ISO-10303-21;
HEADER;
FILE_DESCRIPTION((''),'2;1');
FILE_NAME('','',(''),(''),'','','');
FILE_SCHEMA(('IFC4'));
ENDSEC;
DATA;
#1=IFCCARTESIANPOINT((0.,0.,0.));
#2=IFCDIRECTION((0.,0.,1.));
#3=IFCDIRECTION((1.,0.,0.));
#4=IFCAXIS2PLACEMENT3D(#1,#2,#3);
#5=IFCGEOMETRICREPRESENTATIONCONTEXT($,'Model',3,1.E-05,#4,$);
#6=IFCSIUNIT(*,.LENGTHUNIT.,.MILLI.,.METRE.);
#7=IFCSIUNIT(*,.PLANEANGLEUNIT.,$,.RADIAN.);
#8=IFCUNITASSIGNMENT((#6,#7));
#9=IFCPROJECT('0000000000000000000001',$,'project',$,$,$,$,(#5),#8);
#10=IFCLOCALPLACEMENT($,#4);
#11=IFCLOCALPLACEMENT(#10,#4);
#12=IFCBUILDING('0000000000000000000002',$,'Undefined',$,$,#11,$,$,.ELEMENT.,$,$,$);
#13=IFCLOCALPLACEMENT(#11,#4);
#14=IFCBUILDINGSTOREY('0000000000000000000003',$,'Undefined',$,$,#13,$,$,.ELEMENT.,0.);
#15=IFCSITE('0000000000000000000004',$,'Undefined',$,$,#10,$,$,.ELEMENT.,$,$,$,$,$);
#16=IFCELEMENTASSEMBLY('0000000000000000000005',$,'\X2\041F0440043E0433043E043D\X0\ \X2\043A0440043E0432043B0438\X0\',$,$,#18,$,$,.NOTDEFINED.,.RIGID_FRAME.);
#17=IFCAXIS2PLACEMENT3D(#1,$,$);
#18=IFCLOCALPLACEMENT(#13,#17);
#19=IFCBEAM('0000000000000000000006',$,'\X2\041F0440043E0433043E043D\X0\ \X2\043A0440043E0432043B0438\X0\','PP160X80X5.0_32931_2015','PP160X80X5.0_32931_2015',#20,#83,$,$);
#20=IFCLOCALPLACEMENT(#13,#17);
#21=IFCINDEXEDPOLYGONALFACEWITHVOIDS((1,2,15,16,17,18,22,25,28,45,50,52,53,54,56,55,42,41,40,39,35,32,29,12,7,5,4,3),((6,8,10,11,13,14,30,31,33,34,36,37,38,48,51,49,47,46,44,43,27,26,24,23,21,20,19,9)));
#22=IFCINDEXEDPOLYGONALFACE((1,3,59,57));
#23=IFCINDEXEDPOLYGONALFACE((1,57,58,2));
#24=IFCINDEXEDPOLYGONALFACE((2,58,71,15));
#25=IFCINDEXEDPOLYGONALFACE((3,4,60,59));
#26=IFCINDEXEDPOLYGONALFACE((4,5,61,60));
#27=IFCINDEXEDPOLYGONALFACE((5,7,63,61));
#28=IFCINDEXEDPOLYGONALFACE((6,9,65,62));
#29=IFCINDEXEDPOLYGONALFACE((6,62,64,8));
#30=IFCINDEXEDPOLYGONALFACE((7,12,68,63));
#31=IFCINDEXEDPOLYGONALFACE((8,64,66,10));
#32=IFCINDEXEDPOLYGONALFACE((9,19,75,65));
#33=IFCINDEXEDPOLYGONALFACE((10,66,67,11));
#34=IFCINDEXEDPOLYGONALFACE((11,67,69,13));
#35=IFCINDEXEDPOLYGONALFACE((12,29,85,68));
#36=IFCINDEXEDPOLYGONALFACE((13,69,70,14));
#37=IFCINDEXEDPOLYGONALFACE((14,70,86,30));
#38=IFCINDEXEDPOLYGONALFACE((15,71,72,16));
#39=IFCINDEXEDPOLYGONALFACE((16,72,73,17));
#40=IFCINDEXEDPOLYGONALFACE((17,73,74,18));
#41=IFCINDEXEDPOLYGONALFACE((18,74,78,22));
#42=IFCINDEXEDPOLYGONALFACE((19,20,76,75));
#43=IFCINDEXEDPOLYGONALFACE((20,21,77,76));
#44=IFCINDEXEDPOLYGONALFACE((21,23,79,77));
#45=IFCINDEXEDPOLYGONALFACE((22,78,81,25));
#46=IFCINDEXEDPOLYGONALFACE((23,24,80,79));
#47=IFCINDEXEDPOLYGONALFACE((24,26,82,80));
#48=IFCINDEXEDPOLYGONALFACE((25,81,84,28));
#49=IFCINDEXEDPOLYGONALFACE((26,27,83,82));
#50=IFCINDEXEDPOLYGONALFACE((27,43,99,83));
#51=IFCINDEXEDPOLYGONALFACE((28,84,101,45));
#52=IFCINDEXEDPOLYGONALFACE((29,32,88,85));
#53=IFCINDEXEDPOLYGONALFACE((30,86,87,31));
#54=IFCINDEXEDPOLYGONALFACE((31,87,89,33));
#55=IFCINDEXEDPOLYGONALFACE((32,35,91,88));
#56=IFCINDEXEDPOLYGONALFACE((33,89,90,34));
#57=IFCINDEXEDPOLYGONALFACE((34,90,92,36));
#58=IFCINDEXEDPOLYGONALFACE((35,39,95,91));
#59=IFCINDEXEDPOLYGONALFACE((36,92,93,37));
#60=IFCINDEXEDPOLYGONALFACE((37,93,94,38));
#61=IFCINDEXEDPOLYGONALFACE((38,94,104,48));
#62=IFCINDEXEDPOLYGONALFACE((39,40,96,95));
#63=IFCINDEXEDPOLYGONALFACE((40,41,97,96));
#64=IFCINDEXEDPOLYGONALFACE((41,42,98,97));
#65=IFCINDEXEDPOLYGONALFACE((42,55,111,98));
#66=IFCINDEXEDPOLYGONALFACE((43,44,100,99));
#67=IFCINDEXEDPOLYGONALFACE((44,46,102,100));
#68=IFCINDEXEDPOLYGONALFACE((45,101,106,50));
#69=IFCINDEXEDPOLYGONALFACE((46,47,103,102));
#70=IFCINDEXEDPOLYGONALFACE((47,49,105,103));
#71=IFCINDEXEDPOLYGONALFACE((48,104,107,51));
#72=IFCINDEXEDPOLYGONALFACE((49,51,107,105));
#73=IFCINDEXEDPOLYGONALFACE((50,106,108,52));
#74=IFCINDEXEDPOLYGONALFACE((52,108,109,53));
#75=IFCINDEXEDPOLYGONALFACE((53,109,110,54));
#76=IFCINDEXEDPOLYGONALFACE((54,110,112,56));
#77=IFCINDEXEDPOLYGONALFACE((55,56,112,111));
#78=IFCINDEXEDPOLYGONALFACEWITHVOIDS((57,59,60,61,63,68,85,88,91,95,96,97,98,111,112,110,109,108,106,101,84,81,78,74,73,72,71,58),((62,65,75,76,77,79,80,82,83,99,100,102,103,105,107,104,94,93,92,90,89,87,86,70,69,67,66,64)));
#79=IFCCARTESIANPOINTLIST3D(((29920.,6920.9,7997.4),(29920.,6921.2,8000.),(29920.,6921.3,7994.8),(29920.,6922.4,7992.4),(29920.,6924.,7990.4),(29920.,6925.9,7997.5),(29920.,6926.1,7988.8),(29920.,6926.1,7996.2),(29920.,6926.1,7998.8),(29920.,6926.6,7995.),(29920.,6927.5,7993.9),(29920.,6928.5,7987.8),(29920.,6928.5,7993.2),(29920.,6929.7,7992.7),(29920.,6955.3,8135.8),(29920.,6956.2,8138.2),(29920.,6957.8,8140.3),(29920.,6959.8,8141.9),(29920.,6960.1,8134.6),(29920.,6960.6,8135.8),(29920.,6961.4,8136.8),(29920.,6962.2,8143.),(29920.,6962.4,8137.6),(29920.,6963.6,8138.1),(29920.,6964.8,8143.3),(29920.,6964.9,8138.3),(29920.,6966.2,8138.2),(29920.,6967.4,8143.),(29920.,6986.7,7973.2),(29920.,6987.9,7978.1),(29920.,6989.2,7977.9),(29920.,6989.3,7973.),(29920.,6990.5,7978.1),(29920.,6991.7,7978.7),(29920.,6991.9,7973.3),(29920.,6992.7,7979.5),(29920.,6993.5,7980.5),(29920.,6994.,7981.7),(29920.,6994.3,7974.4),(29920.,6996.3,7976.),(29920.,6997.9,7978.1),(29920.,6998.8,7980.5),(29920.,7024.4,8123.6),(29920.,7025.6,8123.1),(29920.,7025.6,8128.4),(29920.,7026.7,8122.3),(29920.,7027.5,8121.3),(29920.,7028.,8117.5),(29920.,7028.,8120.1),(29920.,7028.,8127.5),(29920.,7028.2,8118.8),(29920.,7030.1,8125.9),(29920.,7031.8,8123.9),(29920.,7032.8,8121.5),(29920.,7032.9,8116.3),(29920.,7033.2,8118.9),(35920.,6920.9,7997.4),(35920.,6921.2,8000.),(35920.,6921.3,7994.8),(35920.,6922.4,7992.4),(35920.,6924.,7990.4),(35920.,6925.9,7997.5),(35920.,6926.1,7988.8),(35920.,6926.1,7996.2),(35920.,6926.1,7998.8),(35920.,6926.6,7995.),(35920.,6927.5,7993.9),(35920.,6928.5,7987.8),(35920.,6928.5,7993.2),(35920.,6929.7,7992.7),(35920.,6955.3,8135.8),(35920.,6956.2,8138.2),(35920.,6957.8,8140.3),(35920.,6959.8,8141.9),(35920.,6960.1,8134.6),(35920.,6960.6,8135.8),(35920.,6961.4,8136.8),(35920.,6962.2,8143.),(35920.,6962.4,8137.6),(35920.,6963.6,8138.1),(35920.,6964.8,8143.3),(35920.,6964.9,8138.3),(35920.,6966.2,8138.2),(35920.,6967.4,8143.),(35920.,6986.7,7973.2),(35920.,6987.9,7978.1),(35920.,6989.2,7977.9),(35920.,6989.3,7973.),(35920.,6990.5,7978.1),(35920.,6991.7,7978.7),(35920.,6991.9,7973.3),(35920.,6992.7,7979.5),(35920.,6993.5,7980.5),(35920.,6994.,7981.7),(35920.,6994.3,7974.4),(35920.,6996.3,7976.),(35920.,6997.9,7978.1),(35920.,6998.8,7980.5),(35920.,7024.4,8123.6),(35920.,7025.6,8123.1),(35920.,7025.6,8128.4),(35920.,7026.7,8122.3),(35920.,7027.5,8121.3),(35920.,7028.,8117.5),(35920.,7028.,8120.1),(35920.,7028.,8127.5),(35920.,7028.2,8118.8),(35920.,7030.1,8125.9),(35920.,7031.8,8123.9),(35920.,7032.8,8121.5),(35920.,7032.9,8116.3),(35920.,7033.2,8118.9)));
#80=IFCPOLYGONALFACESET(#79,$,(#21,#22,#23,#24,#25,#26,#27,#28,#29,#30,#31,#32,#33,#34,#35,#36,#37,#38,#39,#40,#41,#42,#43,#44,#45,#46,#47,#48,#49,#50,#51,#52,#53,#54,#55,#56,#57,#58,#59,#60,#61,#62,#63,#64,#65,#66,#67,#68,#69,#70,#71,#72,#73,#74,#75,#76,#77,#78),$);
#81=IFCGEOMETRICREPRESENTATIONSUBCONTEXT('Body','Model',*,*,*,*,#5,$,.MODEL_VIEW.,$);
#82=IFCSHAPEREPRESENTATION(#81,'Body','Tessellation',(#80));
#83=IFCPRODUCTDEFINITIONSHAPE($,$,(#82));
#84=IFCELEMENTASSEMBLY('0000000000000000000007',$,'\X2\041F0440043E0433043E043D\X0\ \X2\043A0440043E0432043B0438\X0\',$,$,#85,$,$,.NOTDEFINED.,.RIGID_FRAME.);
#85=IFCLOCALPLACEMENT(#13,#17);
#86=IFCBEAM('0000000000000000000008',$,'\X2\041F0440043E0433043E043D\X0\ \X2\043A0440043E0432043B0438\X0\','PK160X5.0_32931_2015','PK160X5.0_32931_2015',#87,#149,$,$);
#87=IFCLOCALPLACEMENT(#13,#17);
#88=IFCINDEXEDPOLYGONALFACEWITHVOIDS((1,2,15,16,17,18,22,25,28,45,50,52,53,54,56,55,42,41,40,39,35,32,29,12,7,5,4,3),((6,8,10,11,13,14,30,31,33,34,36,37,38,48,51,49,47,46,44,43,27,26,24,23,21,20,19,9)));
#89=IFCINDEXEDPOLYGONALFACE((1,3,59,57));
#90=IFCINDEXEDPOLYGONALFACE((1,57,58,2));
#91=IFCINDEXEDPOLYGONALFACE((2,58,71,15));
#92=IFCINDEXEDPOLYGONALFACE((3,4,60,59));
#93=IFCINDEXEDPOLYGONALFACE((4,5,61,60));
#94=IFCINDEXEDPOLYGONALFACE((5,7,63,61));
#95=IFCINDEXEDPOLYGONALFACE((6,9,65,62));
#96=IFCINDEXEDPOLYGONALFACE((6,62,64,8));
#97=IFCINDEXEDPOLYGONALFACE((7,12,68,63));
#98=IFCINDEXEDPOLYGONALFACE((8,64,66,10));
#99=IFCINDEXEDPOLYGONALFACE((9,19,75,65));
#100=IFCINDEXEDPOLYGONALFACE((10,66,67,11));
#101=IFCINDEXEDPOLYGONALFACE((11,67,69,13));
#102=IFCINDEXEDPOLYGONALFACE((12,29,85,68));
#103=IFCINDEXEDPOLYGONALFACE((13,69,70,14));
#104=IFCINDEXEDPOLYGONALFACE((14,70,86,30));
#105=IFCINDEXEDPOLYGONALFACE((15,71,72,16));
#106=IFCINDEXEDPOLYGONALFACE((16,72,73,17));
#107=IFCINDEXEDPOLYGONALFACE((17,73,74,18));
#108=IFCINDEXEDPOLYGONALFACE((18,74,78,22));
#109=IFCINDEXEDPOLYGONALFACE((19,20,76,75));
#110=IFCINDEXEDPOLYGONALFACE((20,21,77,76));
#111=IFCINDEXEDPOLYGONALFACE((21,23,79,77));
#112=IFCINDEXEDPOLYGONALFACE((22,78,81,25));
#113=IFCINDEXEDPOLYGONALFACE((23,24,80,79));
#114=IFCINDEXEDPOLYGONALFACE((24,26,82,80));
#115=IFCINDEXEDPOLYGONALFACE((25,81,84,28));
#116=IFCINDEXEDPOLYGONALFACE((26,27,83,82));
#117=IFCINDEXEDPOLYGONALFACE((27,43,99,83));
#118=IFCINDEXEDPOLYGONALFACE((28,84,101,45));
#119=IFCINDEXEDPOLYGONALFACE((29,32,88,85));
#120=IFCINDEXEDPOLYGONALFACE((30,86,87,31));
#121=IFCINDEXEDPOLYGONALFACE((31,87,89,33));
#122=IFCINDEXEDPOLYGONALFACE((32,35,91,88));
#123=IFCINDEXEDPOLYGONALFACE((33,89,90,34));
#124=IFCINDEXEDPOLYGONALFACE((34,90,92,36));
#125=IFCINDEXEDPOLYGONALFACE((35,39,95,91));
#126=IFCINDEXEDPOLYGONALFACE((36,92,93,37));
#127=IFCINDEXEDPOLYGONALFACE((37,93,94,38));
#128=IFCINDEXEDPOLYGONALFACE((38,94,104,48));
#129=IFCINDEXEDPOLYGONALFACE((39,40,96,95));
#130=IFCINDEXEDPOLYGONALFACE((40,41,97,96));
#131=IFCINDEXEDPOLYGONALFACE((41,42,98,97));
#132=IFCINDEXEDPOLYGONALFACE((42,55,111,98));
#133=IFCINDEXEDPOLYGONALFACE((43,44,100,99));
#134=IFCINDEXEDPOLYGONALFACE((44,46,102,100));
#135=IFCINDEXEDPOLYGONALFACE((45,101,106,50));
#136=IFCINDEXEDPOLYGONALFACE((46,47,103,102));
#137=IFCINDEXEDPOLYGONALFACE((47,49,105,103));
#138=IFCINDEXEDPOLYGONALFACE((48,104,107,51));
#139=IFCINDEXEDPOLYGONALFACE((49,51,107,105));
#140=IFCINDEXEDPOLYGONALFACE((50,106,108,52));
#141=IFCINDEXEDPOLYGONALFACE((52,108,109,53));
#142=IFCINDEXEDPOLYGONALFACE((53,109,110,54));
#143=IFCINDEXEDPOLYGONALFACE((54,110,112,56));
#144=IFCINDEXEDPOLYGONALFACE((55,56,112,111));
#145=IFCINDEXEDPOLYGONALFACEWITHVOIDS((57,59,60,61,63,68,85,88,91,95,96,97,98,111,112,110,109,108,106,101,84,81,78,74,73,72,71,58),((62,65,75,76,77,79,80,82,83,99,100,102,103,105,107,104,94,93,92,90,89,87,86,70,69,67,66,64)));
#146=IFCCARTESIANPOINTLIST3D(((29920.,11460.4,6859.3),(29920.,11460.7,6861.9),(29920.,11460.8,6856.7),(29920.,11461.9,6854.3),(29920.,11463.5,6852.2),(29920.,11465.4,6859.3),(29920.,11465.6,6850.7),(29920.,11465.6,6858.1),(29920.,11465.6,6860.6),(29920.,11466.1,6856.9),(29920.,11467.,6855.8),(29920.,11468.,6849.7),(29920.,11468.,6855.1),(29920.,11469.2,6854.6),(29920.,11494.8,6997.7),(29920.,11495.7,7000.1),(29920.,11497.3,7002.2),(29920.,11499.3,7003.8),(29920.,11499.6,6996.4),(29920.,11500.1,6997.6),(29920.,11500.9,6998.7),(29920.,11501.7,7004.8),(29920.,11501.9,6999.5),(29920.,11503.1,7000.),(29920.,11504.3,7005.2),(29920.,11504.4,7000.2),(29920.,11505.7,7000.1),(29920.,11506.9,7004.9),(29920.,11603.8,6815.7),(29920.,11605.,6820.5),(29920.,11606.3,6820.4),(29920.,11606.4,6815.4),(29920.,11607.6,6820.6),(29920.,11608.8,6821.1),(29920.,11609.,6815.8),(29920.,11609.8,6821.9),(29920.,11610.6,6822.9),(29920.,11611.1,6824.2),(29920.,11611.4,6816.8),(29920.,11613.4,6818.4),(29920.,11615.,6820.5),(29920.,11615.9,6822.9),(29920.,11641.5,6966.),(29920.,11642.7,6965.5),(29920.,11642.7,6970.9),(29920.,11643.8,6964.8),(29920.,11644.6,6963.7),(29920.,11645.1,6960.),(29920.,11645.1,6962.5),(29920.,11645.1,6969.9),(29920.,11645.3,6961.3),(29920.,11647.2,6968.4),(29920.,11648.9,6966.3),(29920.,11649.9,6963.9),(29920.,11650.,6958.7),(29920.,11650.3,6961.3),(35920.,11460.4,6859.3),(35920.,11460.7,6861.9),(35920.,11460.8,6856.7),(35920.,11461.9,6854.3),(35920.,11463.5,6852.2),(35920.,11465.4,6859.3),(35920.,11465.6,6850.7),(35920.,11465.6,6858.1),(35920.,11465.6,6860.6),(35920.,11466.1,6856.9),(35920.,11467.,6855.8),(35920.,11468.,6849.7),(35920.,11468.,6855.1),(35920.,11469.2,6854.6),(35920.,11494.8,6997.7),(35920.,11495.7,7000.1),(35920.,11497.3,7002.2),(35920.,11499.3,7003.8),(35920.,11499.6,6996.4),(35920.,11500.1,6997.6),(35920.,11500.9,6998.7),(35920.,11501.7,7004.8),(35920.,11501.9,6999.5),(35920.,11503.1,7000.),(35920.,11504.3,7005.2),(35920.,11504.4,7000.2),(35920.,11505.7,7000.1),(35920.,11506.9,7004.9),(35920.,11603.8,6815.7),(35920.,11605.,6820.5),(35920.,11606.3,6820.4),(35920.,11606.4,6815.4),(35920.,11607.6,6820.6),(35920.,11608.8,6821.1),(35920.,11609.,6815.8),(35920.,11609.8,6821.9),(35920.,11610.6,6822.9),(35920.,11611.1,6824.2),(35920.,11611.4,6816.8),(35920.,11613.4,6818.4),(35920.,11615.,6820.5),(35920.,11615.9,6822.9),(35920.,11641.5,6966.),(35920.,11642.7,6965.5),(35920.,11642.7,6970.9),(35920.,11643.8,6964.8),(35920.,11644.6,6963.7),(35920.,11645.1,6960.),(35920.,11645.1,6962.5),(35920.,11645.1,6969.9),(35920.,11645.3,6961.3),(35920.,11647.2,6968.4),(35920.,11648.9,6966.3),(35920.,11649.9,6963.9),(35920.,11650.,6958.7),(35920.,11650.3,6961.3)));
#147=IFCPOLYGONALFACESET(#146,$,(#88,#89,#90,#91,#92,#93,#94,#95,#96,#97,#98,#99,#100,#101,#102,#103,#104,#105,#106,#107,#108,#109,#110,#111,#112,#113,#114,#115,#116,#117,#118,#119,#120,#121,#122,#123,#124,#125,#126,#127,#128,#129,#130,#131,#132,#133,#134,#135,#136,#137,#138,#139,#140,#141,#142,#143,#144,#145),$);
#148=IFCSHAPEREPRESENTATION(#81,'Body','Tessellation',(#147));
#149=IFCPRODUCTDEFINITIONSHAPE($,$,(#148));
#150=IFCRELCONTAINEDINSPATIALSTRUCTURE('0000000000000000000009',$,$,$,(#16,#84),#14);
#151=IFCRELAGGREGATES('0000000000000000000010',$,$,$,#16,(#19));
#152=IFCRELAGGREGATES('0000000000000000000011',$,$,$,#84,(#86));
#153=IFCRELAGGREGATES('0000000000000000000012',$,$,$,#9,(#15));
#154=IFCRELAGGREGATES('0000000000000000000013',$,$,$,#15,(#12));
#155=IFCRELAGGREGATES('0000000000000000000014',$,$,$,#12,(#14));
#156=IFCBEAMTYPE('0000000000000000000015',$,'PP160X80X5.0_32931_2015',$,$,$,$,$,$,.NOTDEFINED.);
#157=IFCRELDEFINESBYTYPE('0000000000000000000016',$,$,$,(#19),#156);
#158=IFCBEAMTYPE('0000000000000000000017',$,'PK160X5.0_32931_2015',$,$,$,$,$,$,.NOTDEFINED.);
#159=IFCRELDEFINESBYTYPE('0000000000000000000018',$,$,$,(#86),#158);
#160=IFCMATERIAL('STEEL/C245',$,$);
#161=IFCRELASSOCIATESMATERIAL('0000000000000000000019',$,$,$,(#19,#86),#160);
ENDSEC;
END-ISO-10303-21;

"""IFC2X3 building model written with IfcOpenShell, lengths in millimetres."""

from ifc_helpers import new_model, si_unit, frame, origin_with_axes, origin_2d_with_axis, place, context, subcontext, project, spatial, hollow_rectangle, extrude, material, type_object, element, aggregate, save


model = new_model("IFC2X3")

# Units and contexts
model_context = context("Model", 3, precision=1e-05, world=origin_with_axes())
body_context = subcontext(model_context, "Body", "Model", "MODEL_VIEW")
ifc_project = project(units=[si_unit("LENGTHUNIT", "METRE", prefix="MILLI"), si_unit("PLANEANGLEUNIT", "RADIAN")], contexts=[model_context])

# Site, building, storey
site_placement = place(None, origin_with_axes())
site = spatial("IfcSite", under=ifc_project, at=site_placement, Name="Undefined", CompositionType="ELEMENT")
building_placement = place(site_placement, origin_with_axes())
building = spatial("IfcBuilding", under=site, at=building_placement, Name="Undefined", CompositionType="ELEMENT")
storey_placement = place(building_placement, origin_with_axes())
storey = spatial("IfcBuildingStorey", under=building, at=storey_placement, Name="Undefined", CompositionType="ELEMENT", Elevation=0.0)

# Shared definitions
ifc_material = material(Name="STEEL/C245")

# Element assemblies, beams
beam_type_1 = type_object("IfcBeamType", Name="PP160X80X5.0_32931_2015", PredefinedType="NOTDEFINED")
assembly_1_placement = place(storey_placement, origin_with_axes())
assembly_1 = element("IfcElementAssembly", 1, at=assembly_1_placement, inside=storey, Name="Прогон кровли", AssemblyPlace="NOTDEFINED", PredefinedType="RIGID_FRAME")
beam_1_placement = place(assembly_1_placement, frame((29920.0, 6977.1, 8058.1), z_axis=(0.0, 0.243188, 0.969979), x_axis=(1.0, 0.0, 0.0)))
beam_1 = element("IfcBeam", 2, at=beam_1_placement, type_object=beam_type_1, material=ifc_material, Name="Прогон кровли", Description="PP160X80X5.0_32931_2015", ObjectType="PP160X80X5.0_32931_2015", context=body_context, shape_type="SweptSolid", body=[
    extrude(hollow_rectangle(XDim=80.0, YDim=160.0, WallThickness=5.0, InnerFilletRadius=5.0, OuterFilletRadius=10.0, at=origin_2d_with_axis()), frame((6000.0, 0.0, 0.0), z_axis=(-1.0, 0.0, 0.0), x_axis=(0.0, -1.0, 0.0)), (0.0, 0.0, 1.0), 6000.0),
])
aggregate(assembly_1, [beam_1])
assembly_2_placement = place(storey_placement, origin_with_axes())
assembly_2 = element("IfcElementAssembly", 3, at=assembly_2_placement, inside=storey, Name="Прогон кровли", AssemblyPlace="NOTDEFINED", PredefinedType="RIGID_FRAME")
beam_type_2 = type_object("IfcBeamType", Name="PK160X5.0_32931_2015", PredefinedType="NOTDEFINED")
beam_2_placement = place(assembly_2_placement, frame((29920.0, 11555.4, 6910.3), z_axis=(0.0, 0.243188, 0.969979), x_axis=(1.0, 0.0, 0.0)))
beam_2 = element("IfcBeam", 4, at=beam_2_placement, type_object=beam_type_2, material=ifc_material, Name="Прогон кровли", Description="PK160X5.0_32931_2015", ObjectType="PK160X5.0_32931_2015", context=body_context, shape_type="SweptSolid", body=[
    extrude(hollow_rectangle(XDim=160.0, YDim=160.0, WallThickness=5.0, InnerFilletRadius=5.0, OuterFilletRadius=10.0, at=origin_2d_with_axis()), frame((6000.0, 0.0, 0.0), z_axis=(-1.0, 0.0, 0.0), x_axis=(0.0, -1.0, 0.0)), (0.0, 0.0, 1.0), 6000.0),
])
aggregate(assembly_2, [beam_2])

save(model, "model.ifc")
